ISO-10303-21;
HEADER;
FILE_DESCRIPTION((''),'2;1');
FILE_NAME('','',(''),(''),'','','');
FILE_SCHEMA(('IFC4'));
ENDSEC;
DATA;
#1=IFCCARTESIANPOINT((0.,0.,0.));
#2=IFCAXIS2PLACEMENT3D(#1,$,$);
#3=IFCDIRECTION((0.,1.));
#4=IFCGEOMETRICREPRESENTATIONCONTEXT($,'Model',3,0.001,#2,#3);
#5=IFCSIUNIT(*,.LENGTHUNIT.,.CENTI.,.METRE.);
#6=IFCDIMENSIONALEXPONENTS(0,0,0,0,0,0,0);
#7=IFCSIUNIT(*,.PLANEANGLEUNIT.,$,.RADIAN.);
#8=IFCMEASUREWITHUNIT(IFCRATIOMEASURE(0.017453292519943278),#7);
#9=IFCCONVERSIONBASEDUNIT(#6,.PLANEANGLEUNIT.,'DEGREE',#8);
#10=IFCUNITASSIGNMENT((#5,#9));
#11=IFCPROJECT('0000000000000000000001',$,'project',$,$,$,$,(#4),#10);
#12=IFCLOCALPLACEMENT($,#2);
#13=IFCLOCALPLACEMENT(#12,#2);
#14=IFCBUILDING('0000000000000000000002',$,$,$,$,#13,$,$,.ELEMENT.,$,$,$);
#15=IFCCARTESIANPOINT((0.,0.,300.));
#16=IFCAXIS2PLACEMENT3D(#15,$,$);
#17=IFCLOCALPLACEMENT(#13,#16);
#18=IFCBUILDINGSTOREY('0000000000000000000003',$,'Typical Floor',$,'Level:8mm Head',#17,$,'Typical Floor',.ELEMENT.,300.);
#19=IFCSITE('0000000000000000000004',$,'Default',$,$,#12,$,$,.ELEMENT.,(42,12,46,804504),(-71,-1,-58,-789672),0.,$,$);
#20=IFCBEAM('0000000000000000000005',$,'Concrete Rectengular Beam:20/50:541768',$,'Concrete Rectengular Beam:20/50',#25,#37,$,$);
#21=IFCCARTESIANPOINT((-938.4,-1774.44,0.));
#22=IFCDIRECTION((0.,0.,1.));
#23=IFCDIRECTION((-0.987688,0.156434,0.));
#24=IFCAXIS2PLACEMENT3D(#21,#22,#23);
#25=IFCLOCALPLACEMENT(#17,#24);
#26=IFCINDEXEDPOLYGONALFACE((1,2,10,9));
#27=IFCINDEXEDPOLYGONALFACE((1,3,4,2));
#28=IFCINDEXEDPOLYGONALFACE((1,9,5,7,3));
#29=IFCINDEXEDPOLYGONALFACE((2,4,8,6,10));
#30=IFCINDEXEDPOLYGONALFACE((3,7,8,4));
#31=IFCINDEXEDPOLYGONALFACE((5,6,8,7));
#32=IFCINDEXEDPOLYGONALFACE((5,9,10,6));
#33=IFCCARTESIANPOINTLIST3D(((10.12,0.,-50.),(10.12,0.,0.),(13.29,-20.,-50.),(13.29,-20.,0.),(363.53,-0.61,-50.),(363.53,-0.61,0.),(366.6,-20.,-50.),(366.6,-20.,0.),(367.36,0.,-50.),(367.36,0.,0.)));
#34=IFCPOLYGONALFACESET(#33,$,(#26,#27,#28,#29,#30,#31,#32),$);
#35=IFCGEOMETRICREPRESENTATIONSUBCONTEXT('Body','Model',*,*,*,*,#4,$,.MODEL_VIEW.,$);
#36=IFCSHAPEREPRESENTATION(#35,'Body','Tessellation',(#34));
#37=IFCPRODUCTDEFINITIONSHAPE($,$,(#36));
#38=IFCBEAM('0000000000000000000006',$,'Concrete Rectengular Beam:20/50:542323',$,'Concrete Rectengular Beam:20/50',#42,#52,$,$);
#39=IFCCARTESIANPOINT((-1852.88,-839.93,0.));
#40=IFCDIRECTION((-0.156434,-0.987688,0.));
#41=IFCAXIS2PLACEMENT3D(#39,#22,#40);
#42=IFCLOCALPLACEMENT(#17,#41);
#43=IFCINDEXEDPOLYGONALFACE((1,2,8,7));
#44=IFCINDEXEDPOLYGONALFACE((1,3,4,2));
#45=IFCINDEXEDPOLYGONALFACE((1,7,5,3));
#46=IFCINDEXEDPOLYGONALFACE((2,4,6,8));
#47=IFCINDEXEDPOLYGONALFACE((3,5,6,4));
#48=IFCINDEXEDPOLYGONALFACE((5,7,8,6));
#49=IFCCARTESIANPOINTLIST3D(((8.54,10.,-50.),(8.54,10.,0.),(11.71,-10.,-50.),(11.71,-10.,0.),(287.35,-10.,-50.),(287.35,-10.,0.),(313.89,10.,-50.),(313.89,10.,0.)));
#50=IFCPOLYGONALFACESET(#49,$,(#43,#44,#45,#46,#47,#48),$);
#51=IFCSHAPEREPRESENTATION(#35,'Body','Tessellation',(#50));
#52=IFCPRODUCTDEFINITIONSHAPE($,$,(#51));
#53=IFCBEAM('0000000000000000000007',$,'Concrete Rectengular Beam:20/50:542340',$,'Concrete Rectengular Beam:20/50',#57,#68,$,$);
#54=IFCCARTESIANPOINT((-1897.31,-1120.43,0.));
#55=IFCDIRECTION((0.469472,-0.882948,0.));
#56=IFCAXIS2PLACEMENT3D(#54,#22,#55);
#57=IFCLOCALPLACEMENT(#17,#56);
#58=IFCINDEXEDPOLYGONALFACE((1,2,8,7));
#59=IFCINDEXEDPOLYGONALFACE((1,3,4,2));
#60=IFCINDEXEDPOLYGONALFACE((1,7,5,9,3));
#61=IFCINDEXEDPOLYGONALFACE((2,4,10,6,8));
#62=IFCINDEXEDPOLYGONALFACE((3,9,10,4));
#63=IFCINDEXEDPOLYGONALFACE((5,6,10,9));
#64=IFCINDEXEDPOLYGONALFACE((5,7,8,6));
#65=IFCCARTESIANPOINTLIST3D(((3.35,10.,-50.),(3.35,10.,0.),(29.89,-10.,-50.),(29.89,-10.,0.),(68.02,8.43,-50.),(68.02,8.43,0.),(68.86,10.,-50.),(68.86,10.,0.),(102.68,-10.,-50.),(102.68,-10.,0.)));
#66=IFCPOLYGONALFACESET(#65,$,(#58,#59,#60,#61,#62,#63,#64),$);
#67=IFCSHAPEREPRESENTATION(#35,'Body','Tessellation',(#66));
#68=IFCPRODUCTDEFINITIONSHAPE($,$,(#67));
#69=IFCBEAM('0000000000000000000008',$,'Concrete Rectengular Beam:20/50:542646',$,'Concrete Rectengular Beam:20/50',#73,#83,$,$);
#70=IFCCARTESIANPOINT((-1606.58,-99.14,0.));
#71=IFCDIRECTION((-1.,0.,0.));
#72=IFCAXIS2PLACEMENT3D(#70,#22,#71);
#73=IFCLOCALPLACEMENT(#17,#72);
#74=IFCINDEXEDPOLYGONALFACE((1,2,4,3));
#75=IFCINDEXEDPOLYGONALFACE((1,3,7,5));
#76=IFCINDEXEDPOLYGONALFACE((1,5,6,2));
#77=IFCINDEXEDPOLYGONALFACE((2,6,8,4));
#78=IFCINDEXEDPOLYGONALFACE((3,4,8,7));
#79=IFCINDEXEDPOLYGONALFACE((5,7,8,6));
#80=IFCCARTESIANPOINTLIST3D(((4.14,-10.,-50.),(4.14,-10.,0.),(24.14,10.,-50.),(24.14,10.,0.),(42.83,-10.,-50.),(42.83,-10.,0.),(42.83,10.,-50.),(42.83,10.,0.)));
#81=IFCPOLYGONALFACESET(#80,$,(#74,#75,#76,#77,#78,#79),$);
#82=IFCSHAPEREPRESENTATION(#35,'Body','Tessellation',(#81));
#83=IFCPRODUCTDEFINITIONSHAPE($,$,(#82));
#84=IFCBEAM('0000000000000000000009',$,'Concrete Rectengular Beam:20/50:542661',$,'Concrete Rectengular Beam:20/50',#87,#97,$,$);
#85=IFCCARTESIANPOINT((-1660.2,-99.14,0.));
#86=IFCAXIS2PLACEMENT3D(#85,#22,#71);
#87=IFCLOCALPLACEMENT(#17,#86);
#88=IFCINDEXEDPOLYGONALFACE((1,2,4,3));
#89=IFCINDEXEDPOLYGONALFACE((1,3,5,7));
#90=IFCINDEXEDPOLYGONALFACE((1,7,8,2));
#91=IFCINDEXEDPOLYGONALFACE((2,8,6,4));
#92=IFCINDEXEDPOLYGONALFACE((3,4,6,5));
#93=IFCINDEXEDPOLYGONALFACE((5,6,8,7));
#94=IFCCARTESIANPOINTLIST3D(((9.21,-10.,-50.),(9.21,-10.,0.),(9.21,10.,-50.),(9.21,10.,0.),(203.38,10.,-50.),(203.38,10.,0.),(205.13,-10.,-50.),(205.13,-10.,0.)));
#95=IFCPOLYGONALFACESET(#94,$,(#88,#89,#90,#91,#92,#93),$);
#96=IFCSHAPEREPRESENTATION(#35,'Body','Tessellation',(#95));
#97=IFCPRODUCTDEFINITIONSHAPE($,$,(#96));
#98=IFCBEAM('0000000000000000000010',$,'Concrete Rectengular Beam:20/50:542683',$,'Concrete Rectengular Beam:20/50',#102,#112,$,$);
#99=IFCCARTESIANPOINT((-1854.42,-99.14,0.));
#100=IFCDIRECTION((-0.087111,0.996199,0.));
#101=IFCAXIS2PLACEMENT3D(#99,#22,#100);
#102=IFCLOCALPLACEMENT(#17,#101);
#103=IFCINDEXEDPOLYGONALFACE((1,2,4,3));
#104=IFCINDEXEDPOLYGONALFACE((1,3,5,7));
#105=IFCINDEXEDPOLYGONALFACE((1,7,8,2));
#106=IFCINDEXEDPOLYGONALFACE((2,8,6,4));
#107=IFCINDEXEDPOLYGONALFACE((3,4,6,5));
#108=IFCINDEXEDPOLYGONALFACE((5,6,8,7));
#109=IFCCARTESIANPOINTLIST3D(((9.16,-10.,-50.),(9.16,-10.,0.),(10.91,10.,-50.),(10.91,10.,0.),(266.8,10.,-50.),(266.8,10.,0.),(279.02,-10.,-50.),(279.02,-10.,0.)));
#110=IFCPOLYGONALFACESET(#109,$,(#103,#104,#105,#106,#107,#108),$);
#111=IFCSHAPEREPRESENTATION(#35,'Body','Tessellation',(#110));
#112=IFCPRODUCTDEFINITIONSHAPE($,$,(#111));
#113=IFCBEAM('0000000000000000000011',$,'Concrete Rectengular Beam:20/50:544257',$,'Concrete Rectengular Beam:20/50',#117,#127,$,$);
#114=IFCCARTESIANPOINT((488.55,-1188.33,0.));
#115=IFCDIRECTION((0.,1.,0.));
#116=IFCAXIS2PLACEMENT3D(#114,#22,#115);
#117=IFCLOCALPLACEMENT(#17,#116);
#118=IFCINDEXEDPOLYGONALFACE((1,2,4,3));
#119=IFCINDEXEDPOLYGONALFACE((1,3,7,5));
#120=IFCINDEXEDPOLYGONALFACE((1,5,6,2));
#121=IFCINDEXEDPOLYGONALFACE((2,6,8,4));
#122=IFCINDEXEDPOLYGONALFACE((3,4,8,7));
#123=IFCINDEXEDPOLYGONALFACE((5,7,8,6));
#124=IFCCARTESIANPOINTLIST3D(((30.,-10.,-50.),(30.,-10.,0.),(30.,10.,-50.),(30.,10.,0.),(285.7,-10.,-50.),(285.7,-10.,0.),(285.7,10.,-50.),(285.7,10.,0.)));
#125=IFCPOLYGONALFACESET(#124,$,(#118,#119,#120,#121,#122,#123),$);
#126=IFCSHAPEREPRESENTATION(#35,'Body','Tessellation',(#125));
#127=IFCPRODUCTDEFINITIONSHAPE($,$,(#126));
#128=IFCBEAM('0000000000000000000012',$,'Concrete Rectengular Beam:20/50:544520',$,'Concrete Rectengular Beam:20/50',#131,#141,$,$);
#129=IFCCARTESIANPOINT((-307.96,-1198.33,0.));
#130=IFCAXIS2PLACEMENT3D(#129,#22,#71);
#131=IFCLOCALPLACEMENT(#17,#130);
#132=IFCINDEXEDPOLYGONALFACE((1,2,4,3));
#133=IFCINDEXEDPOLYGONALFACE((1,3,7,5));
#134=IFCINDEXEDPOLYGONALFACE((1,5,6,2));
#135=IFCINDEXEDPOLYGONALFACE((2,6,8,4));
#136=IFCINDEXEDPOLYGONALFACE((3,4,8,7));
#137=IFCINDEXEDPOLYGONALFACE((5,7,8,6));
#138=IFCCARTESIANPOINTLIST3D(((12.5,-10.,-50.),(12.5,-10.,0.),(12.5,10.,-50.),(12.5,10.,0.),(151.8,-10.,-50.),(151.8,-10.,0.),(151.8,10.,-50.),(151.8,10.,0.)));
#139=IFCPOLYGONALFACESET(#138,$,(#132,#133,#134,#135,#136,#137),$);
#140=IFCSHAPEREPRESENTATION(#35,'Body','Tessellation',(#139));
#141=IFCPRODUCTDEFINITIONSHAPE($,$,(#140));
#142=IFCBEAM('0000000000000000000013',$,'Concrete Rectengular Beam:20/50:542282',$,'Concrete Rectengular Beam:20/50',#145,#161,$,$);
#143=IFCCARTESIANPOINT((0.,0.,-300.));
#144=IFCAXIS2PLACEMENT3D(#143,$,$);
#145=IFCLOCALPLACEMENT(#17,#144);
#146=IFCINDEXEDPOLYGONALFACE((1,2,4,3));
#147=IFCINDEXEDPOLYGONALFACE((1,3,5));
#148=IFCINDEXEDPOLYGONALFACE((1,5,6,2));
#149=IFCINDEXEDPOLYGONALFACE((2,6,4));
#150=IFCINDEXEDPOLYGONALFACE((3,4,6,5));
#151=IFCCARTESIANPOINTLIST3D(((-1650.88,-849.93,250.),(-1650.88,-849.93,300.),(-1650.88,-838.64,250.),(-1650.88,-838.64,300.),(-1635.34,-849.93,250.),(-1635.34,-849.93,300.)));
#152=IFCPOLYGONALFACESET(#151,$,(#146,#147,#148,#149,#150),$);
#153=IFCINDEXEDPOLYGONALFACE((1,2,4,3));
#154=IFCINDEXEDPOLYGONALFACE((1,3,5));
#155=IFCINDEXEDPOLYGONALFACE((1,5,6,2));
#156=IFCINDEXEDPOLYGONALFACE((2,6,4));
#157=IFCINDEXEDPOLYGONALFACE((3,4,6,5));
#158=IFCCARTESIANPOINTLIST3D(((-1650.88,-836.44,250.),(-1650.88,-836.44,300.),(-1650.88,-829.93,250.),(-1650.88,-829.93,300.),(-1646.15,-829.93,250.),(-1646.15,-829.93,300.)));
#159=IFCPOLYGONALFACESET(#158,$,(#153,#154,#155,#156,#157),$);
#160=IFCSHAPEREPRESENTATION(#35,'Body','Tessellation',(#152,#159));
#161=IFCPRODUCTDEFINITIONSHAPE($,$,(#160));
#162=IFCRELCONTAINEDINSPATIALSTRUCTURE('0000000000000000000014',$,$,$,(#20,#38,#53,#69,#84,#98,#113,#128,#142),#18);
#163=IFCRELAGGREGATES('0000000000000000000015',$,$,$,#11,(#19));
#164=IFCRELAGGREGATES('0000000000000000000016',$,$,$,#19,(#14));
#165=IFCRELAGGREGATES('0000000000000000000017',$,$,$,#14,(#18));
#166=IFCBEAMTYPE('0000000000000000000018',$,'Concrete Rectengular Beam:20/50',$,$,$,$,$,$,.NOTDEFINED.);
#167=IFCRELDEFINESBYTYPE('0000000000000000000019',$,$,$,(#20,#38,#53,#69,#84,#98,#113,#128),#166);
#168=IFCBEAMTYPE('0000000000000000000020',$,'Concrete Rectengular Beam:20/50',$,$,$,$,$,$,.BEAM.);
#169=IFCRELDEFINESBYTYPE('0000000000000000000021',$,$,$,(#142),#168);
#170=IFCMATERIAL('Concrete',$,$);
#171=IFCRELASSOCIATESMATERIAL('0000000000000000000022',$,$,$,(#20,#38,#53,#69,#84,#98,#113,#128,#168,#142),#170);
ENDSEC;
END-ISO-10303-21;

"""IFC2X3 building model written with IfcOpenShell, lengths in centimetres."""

from ifc_helpers import new_model, entity, si_unit, converted_unit, direction, frame, frame_2d, origin, origin_2d_with_axis, place, context, subcontext, project, spatial, polyline, rectangle, extrude, clip, halfspace, bounded_halfspace, source, transform, mapped, material, type_object, type_shapes, element, save


model = new_model("IFC2X3")

# Units and contexts
model_context = context("Model", 3, precision=0.001, world=origin(), true_north=direction((0.0, 1.0)))
body_context = subcontext(model_context, "Body", "Model", "MODEL_VIEW")
ifc_project = project(units=[si_unit("LENGTHUNIT", "METRE", prefix="CENTI"), converted_unit("PLANEANGLEUNIT", "DEGREE", entity("IfcRatioMeasure", 0.017453292519943278), si_unit("PLANEANGLEUNIT", "RADIAN"), dimensions=[0, 0, 0, 0, 0, 0, 0])], contexts=[model_context])

# Site, building, storey
site_placement = place(None, origin())
site = spatial("IfcSite", under=ifc_project, at=site_placement, Name="Default", CompositionType="ELEMENT", RefLatitude=(42, 12, 46, 804504), RefLongitude=(-71, -1, -58, -789672), RefElevation=0.0)
building_placement = place(site_placement, origin())
building = spatial("IfcBuilding", under=site, at=building_placement, CompositionType="ELEMENT")
storey_placement = place(building_placement, frame((0.0, 0.0, 300.0)))
storey = spatial("IfcBuildingStorey", under=building, at=storey_placement, Name="Typical Floor", ObjectType="Level:8mm Head", LongName="Typical Floor", CompositionType="ELEMENT", Elevation=300.0)

# Beams
ifc_material = material(Name="Concrete")
beam_type_1 = type_object("IfcBeamType", Name="Concrete Rectengular Beam:20/50", PredefinedType="NOTDEFINED")
beam_1_placement = place(storey_placement, frame((-938.4, -1774.44, 0.0), z_axis=(0.0, 0.0, 1.0), x_axis=(-0.987688, 0.156434, 0.0)))
element("IfcBeam", 1, at=beam_1_placement, inside=storey, type_object=beam_type_1, material=ifc_material, Name="Concrete Rectengular Beam:20/50:541768", ObjectType="Concrete Rectengular Beam:20/50", context=body_context, shape_type="SweptSolid", body=[
    clip(clip(clip(extrude(rectangle(XDim=50.0, YDim=20.0, at=origin_2d_with_axis()), frame((10.12, -10.0, -25.0), z_axis=(1.0, 0.0, 0.0), x_axis=(0.0, 0.0, -1.0)), (0.0, 0.0, 1.0), 357.24), halfspace(frame((42.16, -202.27, -50.0), z_axis=(-0.987688, -0.156434, 0.0), x_axis=(-0.156434, 0.987688, 0.0)), False)), bounded_halfspace(frame((363.53, -0.61, 0.0), z_axis=(0.987688, 0.156434, 0.0), x_axis=(0.0, 0.0, -1.0)), False, frame((10.12, -10.0, -25.0), z_axis=(1.0, 0.0, 0.0), x_axis=(0.0, 0.0, -1.0)), polyline([(-25.0, 9.39), (-25.0, -10.0), (-5.0, -10.0), (25.0, -10.0), (25.0, 9.39), (-25.0, 9.39)]))), bounded_halfspace(frame((403.04, 5.65, 0.0), z_axis=(0.156434, -0.987688, 0.0), x_axis=(0.0, 0.0, -1.0)), False, frame((10.12, -10.0, -25.0), z_axis=(1.0, 0.0, 0.0), x_axis=(0.0, 0.0, -1.0)), polyline([(-25.0, 9.39), (25.0, 9.39), (25.0, 10.0), (-25.0, 10.0), (-25.0, 9.39)]))),
])
beam_2_placement = place(storey_placement, frame((-1852.88, -839.93, 0.0), z_axis=(0.0, 0.0, 1.0), x_axis=(-0.156434, -0.987688, 0.0)))
element("IfcBeam", 2, at=beam_2_placement, inside=storey, type_object=beam_type_1, material=ifc_material, Name="Concrete Rectengular Beam:20/50:542323", ObjectType="Concrete Rectengular Beam:20/50", context=body_context, shape_type="SweptSolid", body=[
    clip(clip(extrude(rectangle(XDim=50.0, YDim=20.0, at=frame_2d((0.0, 0.0), x_axis=(1.0, 0.0))), frame((8.54, 0.0, -25.0), z_axis=(1.0, 0.0, 0.0), x_axis=(0.0, 0.0, -1.0)), (0.0, 0.0, 1.0), 305.35), halfspace(frame((263.08, -28.28, -50.0), z_axis=(0.601815, -0.798636, 0.0), x_axis=(0.798636, 0.601815, 0.0)), False)), halfspace(frame((8.13, 12.57, -50.0), z_axis=(-0.987688, -0.156434, 0.0), x_axis=(-0.156434, 0.987688, 0.0)), False)),
])
beam_3_placement = place(storey_placement, frame((-1897.31, -1120.43, 0.0), z_axis=(0.0, 0.0, 1.0), x_axis=(0.469472, -0.882948, 0.0)))
element("IfcBeam", 3, at=beam_3_placement, inside=storey, type_object=beam_type_1, material=ifc_material, Name="Concrete Rectengular Beam:20/50:542340", ObjectType="Concrete Rectengular Beam:20/50", context=body_context, shape_type="SweptSolid", body=[
    clip(clip(clip(extrude(rectangle(XDim=50.0, YDim=20.0, at=frame_2d((0.0, 0.0), x_axis=(1.0, 0.0))), frame((3.35, 0.0, -25.0), z_axis=(1.0, 0.0, 0.0), x_axis=(0.0, 0.0, -1.0)), (0.0, 0.0, 1.0), 99.33), halfspace(frame((0.77, 11.94, -50.0), z_axis=(-0.601815, -0.798636, 0.0), x_axis=(-0.798636, 0.601815, 0.0)), False)), bounded_halfspace(frame((77.41, 26.08, 0.0), z_axis=(0.882948, -0.469472, 0.0), x_axis=(0.0, 0.0, -1.0)), False, frame((3.35, 0.0, -25.0), z_axis=(1.0, 0.0, 0.0), x_axis=(0.0, 0.0, -1.0)), polyline([(-25.0, 8.43), (25.0, 8.43), (25.0, 10.0), (-5.0, 10.0), (-25.0, 10.0), (-25.0, 8.43)]))), bounded_halfspace(frame((68.02, 8.43, 0.0), z_axis=(0.469472, 0.882948, 0.0), x_axis=(0.0, 0.0, -1.0)), False, frame((3.35, 0.0, -25.0), z_axis=(1.0, 0.0, 0.0), x_axis=(0.0, 0.0, -1.0)), polyline([(25.0, 8.43), (-25.0, 8.43), (-25.0, -0.96), (-25.0, -10.0), (25.0, -10.0), (25.0, -0.96), (25.0, 8.43)]))),
])
beam_4_placement = place(storey_placement, frame((-1606.58, -99.14, 0.0), z_axis=(0.0, 0.0, 1.0), x_axis=(-1.0, 0.0, 0.0)))
element("IfcBeam", 4, at=beam_4_placement, inside=storey, type_object=beam_type_1, material=ifc_material, Name="Concrete Rectengular Beam:20/50:542646", ObjectType="Concrete Rectengular Beam:20/50", context=body_context, shape_type="SweptSolid", body=[
    clip(extrude(rectangle(XDim=50.0, YDim=20.0, at=frame_2d((0.0, 0.0), x_axis=(1.0, 0.0))), frame((4.14, 0.0, -25.0), z_axis=(1.0, 0.0, 0.0), x_axis=(0.0, 0.0, -1.0)), (0.0, 0.0, 1.0), 38.68), halfspace(frame((1.17, -12.97, 0.0), z_axis=(-0.707107, 0.707107, 0.0), x_axis=(-0.707107, -0.707107, 0.0)), False)),
])
beam_5_placement = place(storey_placement, frame((-1660.2, -99.14, 0.0), z_axis=(0.0, 0.0, 1.0), x_axis=(-1.0, 0.0, 0.0)))
element("IfcBeam", 5, at=beam_5_placement, inside=storey, type_object=beam_type_1, material=ifc_material, Name="Concrete Rectengular Beam:20/50:542661", ObjectType="Concrete Rectengular Beam:20/50", context=body_context, shape_type="SweptSolid", body=[
    clip(extrude(rectangle(XDim=50.0, YDim=20.0, at=frame_2d((0.0, 0.0), x_axis=(1.0, 0.0))), frame((9.21, 0.0, -25.0), z_axis=(1.0, 0.0, 0.0), x_axis=(0.0, 0.0, -1.0)), (0.0, 0.0, 1.0), 195.92), halfspace(frame((203.08, 13.36, 0.0), z_axis=(0.996199, 0.087111, 0.0), x_axis=(0.087111, -0.996199, 0.0)), False)),
])
beam_6_placement = place(storey_placement, frame((-1854.42, -99.14, 0.0), z_axis=(0.0, 0.0, 1.0), x_axis=(-0.087111, 0.996199, 0.0)))
element("IfcBeam", 6, at=beam_6_placement, inside=storey, type_object=beam_type_1, material=ifc_material, Name="Concrete Rectengular Beam:20/50:542683", ObjectType="Concrete Rectengular Beam:20/50", context=body_context, shape_type="SweptSolid", body=[
    clip(clip(extrude(rectangle(XDim=50.0, YDim=20.0, at=frame_2d((0.0, 0.0), x_axis=(1.0, 0.0))), frame((9.16, 0.0, -25.0), z_axis=(1.0, 0.0, 0.0), x_axis=(0.0, 0.0, -1.0)), (0.0, 0.0, 1.0), 269.85), halfspace(frame((260.09, 20.98, 0.0), z_axis=(0.85332, 0.521387, 0.0), x_axis=(0.521387, -0.85332, 0.0)), False)), halfspace(frame((9.0, -11.91, 0.0), z_axis=(-0.996199, 0.087111, 0.0), x_axis=(-0.087111, -0.996199, 0.0)), False)),
])
beam_7_placement = place(storey_placement, frame((488.55, -1188.33, 0.0), z_axis=(0.0, 0.0, 1.0), x_axis=(0.0, 1.0, 0.0)))
element("IfcBeam", 7, at=beam_7_placement, inside=storey, type_object=beam_type_1, material=ifc_material, Name="Concrete Rectengular Beam:20/50:544257", ObjectType="Concrete Rectengular Beam:20/50", context=body_context, shape_type="SweptSolid", body=[
    extrude(rectangle(XDim=50.0, YDim=20.0, at=frame_2d((0.0, 0.0), x_axis=(1.0, 0.0))), frame((30.0, 0.0, -25.0), z_axis=(1.0, 0.0, 0.0), x_axis=(0.0, 0.0, -1.0)), (0.0, 0.0, 1.0), 255.7),
])
beam_8_placement = place(storey_placement, frame((-307.96, -1198.33, 0.0), z_axis=(0.0, 0.0, 1.0), x_axis=(-1.0, 0.0, 0.0)))
element("IfcBeam", 8, at=beam_8_placement, inside=storey, type_object=beam_type_1, material=ifc_material, Name="Concrete Rectengular Beam:20/50:544520", ObjectType="Concrete Rectengular Beam:20/50", context=body_context, shape_type="SweptSolid", body=[
    extrude(rectangle(XDim=50.0, YDim=20.0, at=frame_2d((0.0, 0.0), x_axis=(1.0, 0.0))), frame((12.5, 0.0, -25.0), z_axis=(1.0, 0.0, 0.0), x_axis=(0.0, 0.0, -1.0)), (0.0, 0.0, 1.0), 139.3),
])
beam_type_2 = type_object("IfcBeamType", Name="Concrete Rectengular Beam:20/50", PredefinedType="BEAM", material=ifc_material)
shared_shape_1 = source(origin(), body_context, "Body", "SweptSolid", [
    clip(extrude(rectangle(XDim=50.0, YDim=11.29, at=origin_2d_with_axis()), frame((-1635.34, -844.28, 275.0), z_axis=(-1.0, 0.0, 0.0), x_axis=(0.0, 0.0, -1.0)), (0.0, 0.0, 1.0), 15.54), halfspace(frame((-1632.19, -852.22, 250.0), z_axis=(0.587785, 0.809017, 0.0), x_axis=(0.809017, -0.587785, 0.0)), False)),
    clip(extrude(rectangle(XDim=50.0, YDim=6.51, at=origin_2d_with_axis()), frame((-1646.15, -833.18, 275.0), z_axis=(-1.0, 0.0, 0.0), x_axis=(0.0, 0.0, -1.0)), (0.0, 0.0, 1.0), 4.73), halfspace(frame((-1646.05, -829.79, 275.0), z_axis=(0.809017, -0.587785, 0.0), x_axis=(0.587785, 0.809017, 0.0)), False)),
])
type_shapes(beam_type_2, [shared_shape_1])
beam_9_placement = place(storey_placement, frame((0.0, 0.0, -300.0)))
element("IfcBeam", 9, at=beam_9_placement, inside=storey, type_object=beam_type_2, material=ifc_material, Name="Concrete Rectengular Beam:20/50:542282", ObjectType="Concrete Rectengular Beam:20/50", context=body_context, shape_type="MappedRepresentation", body=[
    mapped(shared_shape_1, transform((0.0, 0.0, 0.0), scale=1.0)),
])

save(model, "model.ifc")
